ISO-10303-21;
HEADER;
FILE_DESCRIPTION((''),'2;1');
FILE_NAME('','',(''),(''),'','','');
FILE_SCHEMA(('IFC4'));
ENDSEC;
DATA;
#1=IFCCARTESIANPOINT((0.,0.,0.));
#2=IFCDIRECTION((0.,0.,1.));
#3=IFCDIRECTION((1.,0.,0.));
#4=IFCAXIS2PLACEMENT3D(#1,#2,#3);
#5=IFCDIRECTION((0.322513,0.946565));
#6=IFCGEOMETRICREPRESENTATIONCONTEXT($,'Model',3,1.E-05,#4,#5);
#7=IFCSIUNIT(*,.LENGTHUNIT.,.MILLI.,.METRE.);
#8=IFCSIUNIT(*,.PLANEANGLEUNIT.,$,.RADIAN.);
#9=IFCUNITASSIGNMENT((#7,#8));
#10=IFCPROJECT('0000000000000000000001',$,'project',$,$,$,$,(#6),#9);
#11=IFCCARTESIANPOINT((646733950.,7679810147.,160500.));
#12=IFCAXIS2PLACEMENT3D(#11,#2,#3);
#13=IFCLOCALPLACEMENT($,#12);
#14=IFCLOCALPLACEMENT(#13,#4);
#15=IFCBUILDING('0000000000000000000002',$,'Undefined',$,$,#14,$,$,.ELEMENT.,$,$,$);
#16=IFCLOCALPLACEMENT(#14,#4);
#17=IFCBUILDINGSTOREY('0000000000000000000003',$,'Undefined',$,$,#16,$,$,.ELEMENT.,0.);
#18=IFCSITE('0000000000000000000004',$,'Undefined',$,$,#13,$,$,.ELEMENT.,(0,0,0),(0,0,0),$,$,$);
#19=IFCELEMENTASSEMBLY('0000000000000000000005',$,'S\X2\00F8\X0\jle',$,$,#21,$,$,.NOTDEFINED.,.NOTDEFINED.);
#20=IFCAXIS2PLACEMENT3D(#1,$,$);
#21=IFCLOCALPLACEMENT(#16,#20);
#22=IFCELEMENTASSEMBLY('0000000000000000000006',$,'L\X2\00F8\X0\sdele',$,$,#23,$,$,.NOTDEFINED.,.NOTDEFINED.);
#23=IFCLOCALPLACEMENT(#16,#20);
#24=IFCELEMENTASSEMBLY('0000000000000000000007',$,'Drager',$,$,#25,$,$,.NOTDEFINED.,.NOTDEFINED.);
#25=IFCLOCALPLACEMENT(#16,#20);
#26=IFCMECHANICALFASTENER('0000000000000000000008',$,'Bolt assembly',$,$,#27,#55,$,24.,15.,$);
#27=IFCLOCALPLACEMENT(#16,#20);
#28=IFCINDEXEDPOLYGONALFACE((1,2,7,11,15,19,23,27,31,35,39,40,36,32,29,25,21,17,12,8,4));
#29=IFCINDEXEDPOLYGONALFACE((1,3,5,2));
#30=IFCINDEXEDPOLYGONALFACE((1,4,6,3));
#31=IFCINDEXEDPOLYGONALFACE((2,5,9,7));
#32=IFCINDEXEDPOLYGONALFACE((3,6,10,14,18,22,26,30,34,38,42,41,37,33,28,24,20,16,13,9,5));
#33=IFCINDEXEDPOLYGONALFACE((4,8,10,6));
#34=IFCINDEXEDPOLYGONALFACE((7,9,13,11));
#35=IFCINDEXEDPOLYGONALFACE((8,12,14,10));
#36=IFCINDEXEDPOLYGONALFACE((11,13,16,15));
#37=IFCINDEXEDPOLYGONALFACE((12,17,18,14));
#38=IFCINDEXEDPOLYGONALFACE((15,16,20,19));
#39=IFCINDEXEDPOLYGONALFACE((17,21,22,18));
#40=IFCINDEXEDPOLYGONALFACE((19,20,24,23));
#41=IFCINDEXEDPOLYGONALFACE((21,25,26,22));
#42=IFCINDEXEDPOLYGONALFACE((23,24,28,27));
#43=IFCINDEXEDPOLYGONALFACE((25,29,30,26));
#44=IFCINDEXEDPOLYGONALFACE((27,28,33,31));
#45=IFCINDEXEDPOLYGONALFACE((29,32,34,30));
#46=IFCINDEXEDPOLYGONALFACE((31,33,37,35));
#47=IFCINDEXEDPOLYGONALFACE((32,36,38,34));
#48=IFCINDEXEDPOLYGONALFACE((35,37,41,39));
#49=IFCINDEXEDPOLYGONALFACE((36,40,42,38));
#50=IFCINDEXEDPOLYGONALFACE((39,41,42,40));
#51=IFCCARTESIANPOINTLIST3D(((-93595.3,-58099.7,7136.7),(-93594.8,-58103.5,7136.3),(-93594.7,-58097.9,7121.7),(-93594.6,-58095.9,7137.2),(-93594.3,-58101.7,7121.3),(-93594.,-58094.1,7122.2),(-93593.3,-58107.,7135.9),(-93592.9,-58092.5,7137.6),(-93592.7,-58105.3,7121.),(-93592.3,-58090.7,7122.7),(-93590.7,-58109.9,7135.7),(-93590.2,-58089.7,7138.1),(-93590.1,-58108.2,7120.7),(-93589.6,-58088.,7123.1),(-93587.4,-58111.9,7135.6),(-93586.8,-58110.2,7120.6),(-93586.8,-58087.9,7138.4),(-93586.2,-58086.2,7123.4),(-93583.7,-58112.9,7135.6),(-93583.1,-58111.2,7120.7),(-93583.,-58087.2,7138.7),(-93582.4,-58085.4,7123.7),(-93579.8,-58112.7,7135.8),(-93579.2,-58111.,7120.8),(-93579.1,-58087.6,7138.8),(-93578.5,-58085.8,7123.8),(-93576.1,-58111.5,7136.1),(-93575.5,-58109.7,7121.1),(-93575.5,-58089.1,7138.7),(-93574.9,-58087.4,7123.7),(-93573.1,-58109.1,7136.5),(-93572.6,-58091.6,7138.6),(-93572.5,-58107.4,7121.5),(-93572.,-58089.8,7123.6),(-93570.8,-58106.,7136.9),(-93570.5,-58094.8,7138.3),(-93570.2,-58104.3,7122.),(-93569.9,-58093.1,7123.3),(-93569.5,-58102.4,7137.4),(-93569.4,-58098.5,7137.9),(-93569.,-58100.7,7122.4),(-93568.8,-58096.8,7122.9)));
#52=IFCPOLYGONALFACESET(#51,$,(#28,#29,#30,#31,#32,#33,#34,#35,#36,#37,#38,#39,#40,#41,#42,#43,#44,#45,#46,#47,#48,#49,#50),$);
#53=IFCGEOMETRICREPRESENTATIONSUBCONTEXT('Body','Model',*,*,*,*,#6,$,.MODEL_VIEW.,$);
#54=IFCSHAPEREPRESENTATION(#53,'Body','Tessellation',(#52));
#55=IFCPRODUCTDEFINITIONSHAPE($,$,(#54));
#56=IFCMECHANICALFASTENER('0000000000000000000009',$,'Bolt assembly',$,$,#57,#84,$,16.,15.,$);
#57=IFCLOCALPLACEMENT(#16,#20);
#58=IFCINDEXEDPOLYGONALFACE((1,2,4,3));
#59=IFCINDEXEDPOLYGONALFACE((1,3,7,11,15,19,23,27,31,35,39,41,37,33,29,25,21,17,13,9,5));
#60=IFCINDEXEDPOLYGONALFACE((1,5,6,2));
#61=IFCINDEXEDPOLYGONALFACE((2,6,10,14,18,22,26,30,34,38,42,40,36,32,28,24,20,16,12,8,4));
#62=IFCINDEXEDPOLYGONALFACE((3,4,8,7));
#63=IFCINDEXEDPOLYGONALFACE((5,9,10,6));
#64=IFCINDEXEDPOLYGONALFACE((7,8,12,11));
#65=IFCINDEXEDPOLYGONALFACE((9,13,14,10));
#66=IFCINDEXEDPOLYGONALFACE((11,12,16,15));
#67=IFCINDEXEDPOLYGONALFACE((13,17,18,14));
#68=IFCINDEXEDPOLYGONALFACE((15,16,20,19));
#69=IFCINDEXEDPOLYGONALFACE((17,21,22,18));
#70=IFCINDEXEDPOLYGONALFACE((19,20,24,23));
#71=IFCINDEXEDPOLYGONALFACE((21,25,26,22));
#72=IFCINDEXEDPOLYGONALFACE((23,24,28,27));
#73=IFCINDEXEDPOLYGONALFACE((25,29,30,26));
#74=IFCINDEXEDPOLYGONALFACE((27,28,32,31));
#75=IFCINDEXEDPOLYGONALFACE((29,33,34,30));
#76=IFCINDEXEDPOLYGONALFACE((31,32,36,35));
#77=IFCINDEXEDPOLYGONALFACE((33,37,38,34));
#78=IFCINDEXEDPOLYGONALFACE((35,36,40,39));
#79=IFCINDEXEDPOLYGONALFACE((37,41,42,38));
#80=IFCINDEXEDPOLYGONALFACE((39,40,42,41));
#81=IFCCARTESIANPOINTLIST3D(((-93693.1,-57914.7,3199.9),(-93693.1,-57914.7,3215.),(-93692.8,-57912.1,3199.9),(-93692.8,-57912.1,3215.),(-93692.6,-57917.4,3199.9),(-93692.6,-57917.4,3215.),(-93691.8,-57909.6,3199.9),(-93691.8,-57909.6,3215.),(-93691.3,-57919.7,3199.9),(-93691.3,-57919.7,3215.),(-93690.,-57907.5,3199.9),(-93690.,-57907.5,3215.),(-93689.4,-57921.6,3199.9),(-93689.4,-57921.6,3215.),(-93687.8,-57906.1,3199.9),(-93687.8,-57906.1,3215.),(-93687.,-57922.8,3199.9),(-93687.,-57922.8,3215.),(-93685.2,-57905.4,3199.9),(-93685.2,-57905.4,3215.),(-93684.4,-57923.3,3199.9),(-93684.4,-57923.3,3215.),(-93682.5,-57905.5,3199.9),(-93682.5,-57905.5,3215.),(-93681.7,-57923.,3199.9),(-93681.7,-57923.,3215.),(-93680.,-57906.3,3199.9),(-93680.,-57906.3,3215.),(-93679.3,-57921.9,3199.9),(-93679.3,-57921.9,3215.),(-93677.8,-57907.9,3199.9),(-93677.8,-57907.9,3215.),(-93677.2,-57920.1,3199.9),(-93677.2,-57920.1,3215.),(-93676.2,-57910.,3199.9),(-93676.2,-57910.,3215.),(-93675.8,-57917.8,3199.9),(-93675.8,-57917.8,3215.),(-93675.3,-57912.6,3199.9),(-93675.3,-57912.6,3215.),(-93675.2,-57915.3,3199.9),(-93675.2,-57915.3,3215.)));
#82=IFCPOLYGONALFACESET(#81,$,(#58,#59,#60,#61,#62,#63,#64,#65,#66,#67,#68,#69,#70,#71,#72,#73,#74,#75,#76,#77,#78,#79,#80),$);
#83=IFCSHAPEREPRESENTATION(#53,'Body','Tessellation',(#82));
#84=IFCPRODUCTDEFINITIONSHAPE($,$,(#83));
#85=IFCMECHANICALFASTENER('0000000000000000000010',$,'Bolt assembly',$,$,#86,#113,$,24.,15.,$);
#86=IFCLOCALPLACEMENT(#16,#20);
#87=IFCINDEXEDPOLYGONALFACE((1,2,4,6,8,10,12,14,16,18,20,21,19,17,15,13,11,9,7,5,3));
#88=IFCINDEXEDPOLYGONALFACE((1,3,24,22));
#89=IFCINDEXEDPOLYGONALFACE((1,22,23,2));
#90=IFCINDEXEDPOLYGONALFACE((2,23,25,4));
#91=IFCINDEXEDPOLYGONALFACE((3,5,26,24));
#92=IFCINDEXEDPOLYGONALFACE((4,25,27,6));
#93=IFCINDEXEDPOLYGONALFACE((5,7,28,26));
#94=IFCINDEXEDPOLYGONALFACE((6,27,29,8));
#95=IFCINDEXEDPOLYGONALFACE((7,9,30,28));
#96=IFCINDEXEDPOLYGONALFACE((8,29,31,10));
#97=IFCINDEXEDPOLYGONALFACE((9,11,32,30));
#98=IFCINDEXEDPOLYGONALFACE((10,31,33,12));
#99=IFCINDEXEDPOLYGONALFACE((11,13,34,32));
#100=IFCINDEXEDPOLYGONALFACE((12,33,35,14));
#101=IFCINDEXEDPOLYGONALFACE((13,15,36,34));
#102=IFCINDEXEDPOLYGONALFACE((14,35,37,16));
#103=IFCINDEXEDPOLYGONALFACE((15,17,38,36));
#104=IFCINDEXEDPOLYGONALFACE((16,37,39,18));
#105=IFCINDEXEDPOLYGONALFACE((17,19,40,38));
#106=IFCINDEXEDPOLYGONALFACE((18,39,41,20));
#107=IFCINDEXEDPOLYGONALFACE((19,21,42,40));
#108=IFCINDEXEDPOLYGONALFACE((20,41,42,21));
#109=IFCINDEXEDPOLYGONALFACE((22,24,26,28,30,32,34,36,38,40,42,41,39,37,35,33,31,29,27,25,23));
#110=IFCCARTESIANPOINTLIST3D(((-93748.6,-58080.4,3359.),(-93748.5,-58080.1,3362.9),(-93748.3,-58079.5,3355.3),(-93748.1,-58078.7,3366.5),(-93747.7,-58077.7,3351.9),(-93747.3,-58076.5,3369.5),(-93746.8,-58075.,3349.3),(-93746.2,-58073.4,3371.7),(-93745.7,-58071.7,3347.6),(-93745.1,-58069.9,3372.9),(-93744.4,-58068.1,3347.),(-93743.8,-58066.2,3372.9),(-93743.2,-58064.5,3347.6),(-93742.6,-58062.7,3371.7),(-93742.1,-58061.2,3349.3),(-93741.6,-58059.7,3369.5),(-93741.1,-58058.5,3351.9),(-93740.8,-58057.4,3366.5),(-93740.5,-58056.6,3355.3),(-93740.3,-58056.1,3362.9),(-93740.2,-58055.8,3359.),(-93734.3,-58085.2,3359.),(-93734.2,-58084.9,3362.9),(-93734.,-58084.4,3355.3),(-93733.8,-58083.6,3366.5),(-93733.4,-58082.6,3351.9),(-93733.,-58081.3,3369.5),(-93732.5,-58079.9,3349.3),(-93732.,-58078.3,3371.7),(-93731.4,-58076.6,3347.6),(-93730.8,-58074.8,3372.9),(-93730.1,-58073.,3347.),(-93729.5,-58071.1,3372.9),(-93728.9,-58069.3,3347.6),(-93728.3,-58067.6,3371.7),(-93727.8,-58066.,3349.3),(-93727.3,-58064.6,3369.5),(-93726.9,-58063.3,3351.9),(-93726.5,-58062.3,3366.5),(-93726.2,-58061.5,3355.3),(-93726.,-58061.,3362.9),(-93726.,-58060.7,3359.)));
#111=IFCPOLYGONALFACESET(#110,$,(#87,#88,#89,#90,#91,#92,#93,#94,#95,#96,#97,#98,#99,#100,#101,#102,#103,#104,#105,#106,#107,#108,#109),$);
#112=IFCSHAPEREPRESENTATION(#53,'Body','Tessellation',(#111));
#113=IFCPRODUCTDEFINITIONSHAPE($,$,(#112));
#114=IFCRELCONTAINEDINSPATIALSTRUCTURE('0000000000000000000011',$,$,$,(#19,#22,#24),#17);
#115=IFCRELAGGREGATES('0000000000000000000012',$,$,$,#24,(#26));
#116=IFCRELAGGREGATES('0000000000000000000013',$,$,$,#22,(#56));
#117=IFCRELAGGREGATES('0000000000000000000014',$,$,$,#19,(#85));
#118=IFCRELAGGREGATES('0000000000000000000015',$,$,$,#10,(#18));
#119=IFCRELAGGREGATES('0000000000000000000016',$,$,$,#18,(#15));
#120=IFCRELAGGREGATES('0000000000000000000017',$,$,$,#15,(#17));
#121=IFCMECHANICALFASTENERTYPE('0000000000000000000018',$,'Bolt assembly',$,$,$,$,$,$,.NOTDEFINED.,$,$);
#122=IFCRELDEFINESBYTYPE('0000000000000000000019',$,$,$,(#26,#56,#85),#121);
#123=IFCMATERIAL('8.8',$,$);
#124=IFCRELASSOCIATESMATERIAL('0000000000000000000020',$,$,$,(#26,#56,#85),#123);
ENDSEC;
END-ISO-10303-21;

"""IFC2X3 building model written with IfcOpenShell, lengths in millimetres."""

from ifc_helpers import new_model, si_unit, direction, frame, origin_with_axes, origin_2d_with_axis, place, context, subcontext, project, spatial, circle, extrude, source, transform, mapped, material, type_object, element, aggregate, save


model = new_model("IFC2X3")

# Units and contexts
model_context = context("Model", 3, precision=1e-05, world=origin_with_axes(), true_north=direction((0.322513, 0.946565)))
body_context = subcontext(model_context, "Body", "Model", "MODEL_VIEW")
ifc_project = project(units=[si_unit("LENGTHUNIT", "METRE", prefix="MILLI"), si_unit("PLANEANGLEUNIT", "RADIAN")], contexts=[model_context])

# Site, building, storey
site_placement = place(None, frame((646733950.0, 7679810147.0, 160500.0), z_axis=(0.0, 0.0, 1.0), x_axis=(1.0, 0.0, 0.0)))
site = spatial("IfcSite", under=ifc_project, at=site_placement, Name="Undefined", CompositionType="ELEMENT", RefLatitude=(0, 0, 0), RefLongitude=(0, 0, 0))
building_placement = place(site_placement, origin_with_axes())
building = spatial("IfcBuilding", under=site, at=building_placement, Name="Undefined", CompositionType="ELEMENT")
storey_placement = place(building_placement, origin_with_axes())
storey = spatial("IfcBuildingStorey", under=building, at=storey_placement, Name="Undefined", CompositionType="ELEMENT", Elevation=0.0)

# Element assembly
assembly_1_placement = place(storey_placement, origin_with_axes())
assembly_1 = element("IfcElementAssembly", 1, at=assembly_1_placement, inside=storey, Name="Søjle", AssemblyPlace="NOTDEFINED", PredefinedType="NOTDEFINED")

# Element assembly
assembly_2_placement = place(storey_placement, origin_with_axes())
assembly_2 = element("IfcElementAssembly", 2, at=assembly_2_placement, inside=storey, Name="Løsdele", AssemblyPlace="NOTDEFINED", PredefinedType="NOTDEFINED")

# Element assembly
assembly_3_placement = place(storey_placement, origin_with_axes())
assembly_3 = element("IfcElementAssembly", 3, at=assembly_3_placement, inside=storey, Name="Drager", AssemblyPlace="NOTDEFINED", PredefinedType="NOTDEFINED")

# Mechanical fasteners
ifc_material_1 = material(Name="8.8")
mechanical_fastener_type = type_object("IfcMechanicalFastenerType", Name="Bolt assembly")
shared_shape_1 = source(origin_with_axes(), body_context, "Body", "SweptSolid", [
    extrude(circle(Radius=13.0, at=origin_2d_with_axis()), frame((0.0, -7.5, 0.0), z_axis=(0.0, 1.0, 0.0), x_axis=(1.0, 0.0, 0.0)), (0.0, 0.0, 1.0), 15.1),
])
mechanical_fastener_1_placement = place(assembly_3_placement, frame((-93582.0, -58099.2, 7129.7), z_axis=(-0.320109, -0.93951, -0.121869), x_axis=(-0.946565, 0.322513, 0.0)))
mechanical_fastener_1 = element("IfcMechanicalFastener", 4, at=mechanical_fastener_1_placement, type_object=mechanical_fastener_type, material=ifc_material_1, Name="Bolt assembly", NominalDiameter=24.0, NominalLength=15.0, context=body_context, shape_type="MappedRepresentation", body=[
    mapped(shared_shape_1, transform((0.0, 0.0, 0.0))),
])
aggregate(assembly_3, [mechanical_fastener_1])
shared_shape_2 = source(origin_with_axes(), body_context, "Body", "SweptSolid", [
    extrude(circle(Radius=9.0, at=origin_2d_with_axis()), frame((0.0, -15.0, 0.0), z_axis=(0.0, 1.0, 0.0), x_axis=(1.0, 0.0, 0.0)), (0.0, 0.0, 1.0), 15.1),
])
mechanical_fastener_2_placement = place(assembly_2_placement, frame((-93684.1, -57914.3, 3200.0), z_axis=(0.946564, -0.322515, 0.0), x_axis=(-0.322515, -0.946564, 0.0)))
mechanical_fastener_2 = element("IfcMechanicalFastener", 5, at=mechanical_fastener_2_placement, type_object=mechanical_fastener_type, material=ifc_material_1, Name="Bolt assembly", NominalDiameter=16.0, NominalLength=15.0, context=body_context, shape_type="MappedRepresentation", body=[
    mapped(shared_shape_2, transform((0.0, 0.0, 0.0))),
])
aggregate(assembly_2, [mechanical_fastener_2])
shared_shape_3 = source(origin_with_axes(), body_context, "Body", "SweptSolid", [
    extrude(circle(Radius=13.0, at=origin_2d_with_axis()), frame((0.0, -7.5, 0.0), z_axis=(0.0, 1.0, 0.0), x_axis=(1.0, 0.0, 0.0)), (0.0, 0.0, 1.0), 15.1),
])
mechanical_fastener_3_placement = place(assembly_1_placement, frame((-93737.3, -58070.5, 3360.0), z_axis=(-0.322513, -0.946565, 0.0), x_axis=(0.0, 0.0, -1.0)))
mechanical_fastener_3 = element("IfcMechanicalFastener", 6, at=mechanical_fastener_3_placement, type_object=mechanical_fastener_type, material=ifc_material_1, Name="Bolt assembly", NominalDiameter=24.0, NominalLength=15.0, context=body_context, shape_type="MappedRepresentation", body=[
    mapped(shared_shape_3, transform((0.0, 0.0, 0.0))),
])
aggregate(assembly_1, [mechanical_fastener_3])

save(model, "model.ifc")
